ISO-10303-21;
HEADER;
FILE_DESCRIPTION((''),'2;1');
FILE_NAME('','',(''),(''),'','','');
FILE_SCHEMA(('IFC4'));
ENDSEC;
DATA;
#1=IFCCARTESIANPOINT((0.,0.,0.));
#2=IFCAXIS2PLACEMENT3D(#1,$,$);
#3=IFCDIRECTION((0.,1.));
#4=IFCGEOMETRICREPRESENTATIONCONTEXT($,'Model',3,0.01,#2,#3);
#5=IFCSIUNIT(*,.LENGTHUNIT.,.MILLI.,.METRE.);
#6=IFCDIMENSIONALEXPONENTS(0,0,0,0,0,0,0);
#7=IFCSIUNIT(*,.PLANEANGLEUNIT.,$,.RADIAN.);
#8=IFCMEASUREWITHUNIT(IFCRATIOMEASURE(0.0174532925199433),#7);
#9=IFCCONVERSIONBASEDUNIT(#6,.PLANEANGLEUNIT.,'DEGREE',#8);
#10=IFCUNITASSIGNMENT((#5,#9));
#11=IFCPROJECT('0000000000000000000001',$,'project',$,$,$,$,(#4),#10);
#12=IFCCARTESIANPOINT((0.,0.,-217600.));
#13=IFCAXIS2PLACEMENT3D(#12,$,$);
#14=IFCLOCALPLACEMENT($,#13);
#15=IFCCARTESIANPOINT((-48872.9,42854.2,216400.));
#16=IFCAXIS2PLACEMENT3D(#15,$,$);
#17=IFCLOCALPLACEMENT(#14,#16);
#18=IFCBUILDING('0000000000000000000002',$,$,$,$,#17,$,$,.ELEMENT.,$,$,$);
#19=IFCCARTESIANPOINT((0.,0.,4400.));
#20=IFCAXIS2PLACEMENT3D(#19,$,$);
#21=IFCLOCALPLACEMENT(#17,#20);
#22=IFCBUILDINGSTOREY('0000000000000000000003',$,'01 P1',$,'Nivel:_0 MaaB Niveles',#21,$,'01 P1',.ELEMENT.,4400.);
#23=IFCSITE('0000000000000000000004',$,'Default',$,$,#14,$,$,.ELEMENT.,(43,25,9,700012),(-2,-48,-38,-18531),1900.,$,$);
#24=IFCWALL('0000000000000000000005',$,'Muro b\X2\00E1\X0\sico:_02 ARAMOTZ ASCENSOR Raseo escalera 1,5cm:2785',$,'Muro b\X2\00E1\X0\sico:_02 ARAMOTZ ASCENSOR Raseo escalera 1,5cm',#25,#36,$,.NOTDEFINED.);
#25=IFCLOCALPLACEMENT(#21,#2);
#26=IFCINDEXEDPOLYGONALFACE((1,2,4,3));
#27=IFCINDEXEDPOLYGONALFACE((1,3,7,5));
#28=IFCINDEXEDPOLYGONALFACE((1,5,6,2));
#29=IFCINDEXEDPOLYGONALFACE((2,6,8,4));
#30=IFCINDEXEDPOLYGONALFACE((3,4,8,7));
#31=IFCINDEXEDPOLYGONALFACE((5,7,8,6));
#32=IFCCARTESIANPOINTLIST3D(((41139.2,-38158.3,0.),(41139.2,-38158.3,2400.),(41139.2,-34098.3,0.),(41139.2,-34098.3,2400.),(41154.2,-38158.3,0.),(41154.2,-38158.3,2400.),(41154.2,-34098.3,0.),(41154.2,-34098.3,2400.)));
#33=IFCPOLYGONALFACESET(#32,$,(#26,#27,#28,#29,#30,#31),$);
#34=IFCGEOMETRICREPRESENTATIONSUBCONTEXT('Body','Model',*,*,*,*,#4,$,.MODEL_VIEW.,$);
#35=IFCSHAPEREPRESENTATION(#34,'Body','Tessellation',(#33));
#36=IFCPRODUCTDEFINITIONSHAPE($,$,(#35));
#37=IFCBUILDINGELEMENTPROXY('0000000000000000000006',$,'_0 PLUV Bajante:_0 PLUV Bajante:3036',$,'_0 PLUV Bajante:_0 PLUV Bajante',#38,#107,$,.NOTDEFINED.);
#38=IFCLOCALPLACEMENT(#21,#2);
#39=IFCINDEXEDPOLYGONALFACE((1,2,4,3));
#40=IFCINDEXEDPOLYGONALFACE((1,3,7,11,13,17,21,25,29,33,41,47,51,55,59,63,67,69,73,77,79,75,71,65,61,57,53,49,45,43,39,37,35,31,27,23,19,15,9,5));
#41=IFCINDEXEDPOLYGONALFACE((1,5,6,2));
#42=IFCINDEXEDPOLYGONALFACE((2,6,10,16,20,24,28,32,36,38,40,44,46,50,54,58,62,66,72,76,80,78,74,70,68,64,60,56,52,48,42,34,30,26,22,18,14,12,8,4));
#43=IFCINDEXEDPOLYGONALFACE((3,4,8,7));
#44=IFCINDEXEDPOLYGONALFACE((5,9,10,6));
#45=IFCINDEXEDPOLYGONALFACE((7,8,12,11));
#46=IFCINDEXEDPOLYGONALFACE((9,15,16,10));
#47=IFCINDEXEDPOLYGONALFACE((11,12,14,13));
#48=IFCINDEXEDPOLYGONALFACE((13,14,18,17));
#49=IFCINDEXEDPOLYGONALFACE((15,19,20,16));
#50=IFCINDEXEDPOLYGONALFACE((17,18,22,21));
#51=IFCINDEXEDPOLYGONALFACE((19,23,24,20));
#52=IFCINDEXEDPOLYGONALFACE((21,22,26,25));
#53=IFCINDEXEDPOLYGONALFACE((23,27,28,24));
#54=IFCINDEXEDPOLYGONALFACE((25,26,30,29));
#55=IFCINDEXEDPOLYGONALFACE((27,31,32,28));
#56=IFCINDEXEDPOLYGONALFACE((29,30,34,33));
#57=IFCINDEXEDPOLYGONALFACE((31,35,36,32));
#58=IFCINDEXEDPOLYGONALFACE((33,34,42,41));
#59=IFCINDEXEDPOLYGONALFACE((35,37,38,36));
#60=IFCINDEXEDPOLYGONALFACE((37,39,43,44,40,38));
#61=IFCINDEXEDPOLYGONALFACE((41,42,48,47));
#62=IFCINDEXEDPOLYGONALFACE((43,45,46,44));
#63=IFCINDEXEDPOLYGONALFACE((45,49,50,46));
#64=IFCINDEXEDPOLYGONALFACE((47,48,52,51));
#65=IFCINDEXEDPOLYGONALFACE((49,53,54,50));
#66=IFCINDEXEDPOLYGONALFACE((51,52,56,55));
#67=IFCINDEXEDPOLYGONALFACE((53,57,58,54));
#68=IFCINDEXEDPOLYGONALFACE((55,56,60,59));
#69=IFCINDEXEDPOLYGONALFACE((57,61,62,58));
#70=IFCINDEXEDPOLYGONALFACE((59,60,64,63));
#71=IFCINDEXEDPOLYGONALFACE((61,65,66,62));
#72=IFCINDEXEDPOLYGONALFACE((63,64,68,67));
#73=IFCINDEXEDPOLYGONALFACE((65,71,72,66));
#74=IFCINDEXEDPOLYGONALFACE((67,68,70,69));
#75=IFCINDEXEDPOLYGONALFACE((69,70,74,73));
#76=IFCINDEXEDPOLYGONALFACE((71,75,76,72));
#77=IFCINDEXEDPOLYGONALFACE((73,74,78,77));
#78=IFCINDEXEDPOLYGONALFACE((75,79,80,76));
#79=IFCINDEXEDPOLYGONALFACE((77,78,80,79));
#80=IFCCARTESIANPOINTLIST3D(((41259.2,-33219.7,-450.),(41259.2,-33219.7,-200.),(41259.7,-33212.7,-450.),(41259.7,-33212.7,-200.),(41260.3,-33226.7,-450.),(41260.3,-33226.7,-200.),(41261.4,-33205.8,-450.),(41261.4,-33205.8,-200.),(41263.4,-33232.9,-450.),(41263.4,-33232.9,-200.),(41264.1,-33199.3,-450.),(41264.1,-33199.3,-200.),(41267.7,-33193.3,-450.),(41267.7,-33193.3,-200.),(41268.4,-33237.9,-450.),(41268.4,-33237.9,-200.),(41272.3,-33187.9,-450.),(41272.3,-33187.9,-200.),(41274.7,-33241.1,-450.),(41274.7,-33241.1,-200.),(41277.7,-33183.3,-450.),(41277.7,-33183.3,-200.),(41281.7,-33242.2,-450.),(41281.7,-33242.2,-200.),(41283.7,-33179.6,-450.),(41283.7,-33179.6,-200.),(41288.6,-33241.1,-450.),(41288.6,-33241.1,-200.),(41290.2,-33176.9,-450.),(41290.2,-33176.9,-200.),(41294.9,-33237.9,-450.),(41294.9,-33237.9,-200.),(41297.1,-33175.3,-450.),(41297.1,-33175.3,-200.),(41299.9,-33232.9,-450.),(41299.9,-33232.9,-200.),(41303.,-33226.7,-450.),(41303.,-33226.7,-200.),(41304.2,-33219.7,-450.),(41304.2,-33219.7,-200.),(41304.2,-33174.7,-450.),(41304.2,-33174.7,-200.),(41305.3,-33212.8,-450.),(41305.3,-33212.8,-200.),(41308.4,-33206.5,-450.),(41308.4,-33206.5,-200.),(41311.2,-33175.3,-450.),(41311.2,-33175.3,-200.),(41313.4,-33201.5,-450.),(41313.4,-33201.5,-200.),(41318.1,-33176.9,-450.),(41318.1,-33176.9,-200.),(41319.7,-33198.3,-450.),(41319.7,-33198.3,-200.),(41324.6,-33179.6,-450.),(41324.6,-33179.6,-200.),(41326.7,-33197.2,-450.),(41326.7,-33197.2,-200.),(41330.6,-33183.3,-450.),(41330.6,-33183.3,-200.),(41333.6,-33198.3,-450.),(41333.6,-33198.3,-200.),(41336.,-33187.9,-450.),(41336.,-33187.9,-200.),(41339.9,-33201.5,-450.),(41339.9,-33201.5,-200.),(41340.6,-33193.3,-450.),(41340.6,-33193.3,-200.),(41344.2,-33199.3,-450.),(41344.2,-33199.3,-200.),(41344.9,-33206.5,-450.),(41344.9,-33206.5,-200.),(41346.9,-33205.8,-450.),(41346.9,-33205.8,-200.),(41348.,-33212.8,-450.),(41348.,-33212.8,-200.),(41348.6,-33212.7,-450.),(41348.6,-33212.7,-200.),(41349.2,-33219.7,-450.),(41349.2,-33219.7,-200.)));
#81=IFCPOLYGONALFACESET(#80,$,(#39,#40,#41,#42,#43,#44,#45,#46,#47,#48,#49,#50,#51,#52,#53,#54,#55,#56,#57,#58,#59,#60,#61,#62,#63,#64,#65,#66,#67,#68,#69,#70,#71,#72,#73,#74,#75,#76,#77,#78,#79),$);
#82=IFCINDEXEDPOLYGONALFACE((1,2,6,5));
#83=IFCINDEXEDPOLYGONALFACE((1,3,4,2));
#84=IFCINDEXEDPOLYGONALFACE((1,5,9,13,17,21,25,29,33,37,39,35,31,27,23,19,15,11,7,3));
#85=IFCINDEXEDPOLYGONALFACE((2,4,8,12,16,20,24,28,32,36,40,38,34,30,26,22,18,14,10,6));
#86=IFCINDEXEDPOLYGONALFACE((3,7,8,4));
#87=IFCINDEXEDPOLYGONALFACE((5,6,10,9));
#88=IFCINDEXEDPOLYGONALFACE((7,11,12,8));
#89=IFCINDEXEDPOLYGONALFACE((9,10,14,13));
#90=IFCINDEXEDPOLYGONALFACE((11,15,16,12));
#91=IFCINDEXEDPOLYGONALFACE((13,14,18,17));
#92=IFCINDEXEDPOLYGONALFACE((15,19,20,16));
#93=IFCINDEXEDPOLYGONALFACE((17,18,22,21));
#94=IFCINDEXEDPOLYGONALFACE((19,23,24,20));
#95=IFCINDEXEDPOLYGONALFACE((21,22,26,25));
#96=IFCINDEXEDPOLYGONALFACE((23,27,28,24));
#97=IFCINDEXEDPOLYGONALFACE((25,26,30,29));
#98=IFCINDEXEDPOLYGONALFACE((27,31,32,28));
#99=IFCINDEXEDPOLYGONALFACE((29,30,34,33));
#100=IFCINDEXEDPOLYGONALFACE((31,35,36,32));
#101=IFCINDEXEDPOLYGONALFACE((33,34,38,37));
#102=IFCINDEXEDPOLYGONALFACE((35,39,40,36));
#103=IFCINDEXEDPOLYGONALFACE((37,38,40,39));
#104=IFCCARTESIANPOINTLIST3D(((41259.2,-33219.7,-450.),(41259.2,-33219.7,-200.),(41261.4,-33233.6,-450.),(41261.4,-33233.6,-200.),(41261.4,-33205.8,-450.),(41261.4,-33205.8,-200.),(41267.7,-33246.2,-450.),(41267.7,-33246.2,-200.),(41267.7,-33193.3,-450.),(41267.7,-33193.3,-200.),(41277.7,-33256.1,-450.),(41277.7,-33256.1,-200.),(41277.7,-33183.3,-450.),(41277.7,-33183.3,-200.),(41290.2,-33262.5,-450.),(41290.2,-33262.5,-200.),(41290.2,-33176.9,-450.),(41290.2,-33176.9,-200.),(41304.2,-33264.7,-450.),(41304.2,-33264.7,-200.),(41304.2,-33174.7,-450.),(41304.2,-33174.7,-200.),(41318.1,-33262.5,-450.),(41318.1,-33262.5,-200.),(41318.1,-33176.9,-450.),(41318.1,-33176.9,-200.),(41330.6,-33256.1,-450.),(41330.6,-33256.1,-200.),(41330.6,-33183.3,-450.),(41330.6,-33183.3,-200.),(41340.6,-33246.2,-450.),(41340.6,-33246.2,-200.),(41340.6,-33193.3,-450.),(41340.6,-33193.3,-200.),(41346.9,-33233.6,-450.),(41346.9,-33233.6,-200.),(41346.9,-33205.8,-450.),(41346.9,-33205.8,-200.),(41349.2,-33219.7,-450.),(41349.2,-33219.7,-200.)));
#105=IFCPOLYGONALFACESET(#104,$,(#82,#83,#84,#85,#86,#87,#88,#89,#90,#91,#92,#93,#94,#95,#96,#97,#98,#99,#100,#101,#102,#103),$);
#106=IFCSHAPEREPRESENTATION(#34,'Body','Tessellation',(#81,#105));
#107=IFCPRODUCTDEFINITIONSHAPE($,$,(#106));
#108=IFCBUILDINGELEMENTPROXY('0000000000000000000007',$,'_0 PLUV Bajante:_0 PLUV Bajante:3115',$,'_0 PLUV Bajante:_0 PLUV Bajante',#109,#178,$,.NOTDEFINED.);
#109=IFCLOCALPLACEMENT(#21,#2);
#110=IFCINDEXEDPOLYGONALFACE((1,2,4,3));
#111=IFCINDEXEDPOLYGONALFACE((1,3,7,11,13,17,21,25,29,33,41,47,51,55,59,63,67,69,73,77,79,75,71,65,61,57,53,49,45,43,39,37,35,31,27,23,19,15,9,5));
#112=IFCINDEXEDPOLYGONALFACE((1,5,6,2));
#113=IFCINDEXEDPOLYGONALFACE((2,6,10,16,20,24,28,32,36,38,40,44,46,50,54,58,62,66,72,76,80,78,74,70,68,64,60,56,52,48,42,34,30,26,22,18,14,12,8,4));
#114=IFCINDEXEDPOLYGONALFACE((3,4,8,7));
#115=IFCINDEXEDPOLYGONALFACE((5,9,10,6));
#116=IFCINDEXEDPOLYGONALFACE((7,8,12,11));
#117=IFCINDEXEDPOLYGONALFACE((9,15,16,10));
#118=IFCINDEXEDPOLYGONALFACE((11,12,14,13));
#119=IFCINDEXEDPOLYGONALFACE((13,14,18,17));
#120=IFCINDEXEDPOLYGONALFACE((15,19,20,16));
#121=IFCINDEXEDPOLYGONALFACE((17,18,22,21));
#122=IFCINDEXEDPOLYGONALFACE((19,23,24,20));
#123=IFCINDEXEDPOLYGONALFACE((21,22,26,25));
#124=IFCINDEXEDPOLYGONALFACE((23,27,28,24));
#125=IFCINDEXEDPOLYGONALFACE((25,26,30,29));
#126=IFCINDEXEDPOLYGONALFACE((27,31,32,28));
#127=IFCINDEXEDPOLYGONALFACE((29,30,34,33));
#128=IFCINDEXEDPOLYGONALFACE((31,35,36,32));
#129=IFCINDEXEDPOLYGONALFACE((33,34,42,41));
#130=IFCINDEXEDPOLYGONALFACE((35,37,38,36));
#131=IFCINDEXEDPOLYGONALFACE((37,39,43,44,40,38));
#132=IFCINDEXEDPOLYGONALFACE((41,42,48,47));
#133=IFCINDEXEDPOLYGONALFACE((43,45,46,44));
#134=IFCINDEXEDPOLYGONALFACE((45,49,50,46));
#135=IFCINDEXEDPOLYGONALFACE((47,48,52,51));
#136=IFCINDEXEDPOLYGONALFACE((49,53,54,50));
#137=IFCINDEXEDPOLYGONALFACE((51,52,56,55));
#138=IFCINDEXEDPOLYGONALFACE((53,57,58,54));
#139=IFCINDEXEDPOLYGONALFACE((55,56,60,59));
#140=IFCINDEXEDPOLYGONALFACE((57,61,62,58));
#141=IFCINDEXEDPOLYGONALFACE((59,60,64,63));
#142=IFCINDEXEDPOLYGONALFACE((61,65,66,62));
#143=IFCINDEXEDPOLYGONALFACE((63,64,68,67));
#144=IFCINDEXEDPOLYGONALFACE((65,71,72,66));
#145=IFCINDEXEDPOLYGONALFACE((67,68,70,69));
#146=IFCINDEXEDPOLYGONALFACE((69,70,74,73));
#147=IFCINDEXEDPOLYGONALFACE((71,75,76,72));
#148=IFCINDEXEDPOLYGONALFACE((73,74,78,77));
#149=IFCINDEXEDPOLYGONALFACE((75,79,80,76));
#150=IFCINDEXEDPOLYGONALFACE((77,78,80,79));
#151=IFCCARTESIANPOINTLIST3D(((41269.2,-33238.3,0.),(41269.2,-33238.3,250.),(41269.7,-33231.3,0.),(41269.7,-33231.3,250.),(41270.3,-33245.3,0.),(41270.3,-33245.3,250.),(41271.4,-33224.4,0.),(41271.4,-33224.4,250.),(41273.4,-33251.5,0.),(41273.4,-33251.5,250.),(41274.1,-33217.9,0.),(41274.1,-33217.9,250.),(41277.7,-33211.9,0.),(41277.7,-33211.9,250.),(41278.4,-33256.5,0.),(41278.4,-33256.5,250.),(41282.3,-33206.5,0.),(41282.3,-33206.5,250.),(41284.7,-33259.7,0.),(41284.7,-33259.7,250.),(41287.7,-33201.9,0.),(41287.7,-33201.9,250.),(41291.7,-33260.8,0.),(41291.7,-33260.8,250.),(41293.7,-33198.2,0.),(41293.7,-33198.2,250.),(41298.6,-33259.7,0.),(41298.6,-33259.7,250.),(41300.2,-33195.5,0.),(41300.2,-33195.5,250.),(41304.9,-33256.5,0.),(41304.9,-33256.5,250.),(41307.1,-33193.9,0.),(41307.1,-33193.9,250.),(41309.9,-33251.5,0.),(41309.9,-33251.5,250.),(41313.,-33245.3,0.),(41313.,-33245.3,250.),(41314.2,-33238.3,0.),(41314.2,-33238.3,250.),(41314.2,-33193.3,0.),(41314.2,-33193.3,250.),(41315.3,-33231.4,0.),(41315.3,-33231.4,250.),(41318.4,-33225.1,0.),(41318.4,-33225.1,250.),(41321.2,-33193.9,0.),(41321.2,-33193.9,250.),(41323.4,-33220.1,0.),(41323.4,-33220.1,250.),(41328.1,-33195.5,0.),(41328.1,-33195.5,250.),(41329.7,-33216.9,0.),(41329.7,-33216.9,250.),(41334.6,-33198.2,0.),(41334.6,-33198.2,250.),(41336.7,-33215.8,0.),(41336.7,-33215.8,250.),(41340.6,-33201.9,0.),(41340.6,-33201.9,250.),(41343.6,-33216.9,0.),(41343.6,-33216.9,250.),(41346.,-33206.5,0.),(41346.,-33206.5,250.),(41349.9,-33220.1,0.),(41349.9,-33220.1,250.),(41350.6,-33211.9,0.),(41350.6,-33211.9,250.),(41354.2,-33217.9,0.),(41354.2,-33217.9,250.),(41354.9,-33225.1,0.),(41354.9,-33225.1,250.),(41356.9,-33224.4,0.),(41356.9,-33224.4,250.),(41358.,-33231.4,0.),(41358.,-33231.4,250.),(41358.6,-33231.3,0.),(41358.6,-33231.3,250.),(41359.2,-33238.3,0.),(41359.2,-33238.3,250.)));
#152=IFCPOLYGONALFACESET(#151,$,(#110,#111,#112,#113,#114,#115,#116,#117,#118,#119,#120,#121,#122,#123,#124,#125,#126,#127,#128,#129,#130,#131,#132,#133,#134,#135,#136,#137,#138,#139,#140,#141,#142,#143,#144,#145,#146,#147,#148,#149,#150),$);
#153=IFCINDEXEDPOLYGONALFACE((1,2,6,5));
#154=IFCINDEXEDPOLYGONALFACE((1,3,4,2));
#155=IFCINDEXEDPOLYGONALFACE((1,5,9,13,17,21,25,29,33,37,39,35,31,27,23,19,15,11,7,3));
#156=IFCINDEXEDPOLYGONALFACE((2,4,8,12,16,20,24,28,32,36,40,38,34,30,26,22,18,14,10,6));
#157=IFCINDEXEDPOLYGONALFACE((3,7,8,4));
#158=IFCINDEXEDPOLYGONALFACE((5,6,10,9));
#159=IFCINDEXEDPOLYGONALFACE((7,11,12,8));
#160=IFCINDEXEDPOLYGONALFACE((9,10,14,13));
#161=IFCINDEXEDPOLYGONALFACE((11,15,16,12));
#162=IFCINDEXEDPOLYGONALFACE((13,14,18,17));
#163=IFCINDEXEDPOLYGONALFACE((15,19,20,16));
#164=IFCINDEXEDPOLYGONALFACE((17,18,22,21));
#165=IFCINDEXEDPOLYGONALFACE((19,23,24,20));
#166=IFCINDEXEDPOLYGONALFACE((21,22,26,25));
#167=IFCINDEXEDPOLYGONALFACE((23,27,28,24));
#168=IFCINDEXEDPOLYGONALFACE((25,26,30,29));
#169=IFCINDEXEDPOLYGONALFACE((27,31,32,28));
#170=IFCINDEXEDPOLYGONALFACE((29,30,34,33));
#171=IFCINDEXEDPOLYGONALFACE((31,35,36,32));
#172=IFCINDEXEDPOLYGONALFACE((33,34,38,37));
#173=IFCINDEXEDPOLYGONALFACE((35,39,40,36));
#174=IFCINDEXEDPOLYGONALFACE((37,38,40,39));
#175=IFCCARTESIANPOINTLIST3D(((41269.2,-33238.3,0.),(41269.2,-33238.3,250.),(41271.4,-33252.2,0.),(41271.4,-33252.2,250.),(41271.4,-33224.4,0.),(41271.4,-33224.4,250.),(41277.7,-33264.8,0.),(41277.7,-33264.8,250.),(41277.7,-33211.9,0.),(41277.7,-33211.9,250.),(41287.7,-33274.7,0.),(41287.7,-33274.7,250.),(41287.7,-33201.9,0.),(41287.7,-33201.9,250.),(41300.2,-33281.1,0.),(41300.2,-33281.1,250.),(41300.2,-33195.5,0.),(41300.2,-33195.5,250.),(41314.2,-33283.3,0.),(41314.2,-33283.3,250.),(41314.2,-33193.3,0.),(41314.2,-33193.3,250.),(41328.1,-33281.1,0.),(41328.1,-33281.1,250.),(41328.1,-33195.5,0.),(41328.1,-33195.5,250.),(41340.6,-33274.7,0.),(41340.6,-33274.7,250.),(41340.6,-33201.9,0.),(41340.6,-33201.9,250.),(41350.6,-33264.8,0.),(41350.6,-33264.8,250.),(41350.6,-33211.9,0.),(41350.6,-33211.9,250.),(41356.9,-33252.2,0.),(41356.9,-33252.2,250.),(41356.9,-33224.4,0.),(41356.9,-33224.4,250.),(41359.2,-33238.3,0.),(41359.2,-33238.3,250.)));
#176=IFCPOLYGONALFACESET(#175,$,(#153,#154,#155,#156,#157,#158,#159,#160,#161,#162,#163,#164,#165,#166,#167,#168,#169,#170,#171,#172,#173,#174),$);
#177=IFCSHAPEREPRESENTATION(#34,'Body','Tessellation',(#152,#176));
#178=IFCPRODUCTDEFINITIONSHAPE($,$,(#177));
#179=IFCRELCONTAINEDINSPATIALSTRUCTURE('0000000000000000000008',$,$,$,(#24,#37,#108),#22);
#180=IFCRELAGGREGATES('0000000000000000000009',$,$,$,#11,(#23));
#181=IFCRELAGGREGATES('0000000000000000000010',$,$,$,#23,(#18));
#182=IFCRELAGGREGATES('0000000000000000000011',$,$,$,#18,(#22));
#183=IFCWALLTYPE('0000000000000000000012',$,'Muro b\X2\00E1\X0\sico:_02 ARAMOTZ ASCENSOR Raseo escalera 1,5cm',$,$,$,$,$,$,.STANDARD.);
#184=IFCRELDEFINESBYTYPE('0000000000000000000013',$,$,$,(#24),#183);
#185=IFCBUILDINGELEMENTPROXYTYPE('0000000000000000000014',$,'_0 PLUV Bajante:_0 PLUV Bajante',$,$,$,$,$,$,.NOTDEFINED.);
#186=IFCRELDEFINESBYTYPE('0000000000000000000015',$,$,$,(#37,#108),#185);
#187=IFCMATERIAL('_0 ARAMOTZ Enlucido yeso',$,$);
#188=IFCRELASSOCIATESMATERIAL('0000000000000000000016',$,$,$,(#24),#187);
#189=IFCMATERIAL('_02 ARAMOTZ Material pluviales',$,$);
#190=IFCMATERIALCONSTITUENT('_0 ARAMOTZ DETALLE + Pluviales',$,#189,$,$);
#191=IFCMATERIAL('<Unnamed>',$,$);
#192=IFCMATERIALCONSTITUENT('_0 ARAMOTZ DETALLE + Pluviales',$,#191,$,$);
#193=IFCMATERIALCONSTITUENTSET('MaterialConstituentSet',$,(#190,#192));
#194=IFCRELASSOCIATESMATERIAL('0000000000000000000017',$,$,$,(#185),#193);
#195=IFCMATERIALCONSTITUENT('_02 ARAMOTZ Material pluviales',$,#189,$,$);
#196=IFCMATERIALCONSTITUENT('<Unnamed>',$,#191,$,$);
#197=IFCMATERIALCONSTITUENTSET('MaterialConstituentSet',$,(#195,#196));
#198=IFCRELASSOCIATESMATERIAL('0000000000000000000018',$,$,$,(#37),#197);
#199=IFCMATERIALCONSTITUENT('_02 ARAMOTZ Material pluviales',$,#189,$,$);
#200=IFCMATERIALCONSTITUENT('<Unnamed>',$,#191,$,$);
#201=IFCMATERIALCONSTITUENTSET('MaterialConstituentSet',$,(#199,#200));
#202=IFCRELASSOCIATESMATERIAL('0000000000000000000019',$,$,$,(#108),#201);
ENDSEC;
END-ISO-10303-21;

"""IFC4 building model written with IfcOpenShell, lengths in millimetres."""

from ifc_helpers import new_model, entity, si_unit, converted_unit, direction, frame, origin, place, context, subcontext, project, spatial, indexed_curve, outline, extrude, source, transform, mapped, material, constituent, constituent_set, type_object, type_shapes, element, save


model = new_model("IFC4")

# Units and contexts
model_context = context("Model", 3, precision=0.01, world=origin(), true_north=direction((0.0, 1.0)))
body_context = subcontext(model_context, "Body", "Model", "MODEL_VIEW")
ifc_project = project(units=[si_unit("LENGTHUNIT", "METRE", prefix="MILLI"), converted_unit("PLANEANGLEUNIT", "DEGREE", entity("IfcRatioMeasure", 0.0174532925199433), si_unit("PLANEANGLEUNIT", "RADIAN"), dimensions=[0, 0, 0, 0, 0, 0, 0])], contexts=[model_context])

# Site, building, storey
site_placement = place(None, frame((0.0, 0.0, -217600.0)))
site = spatial("IfcSite", under=ifc_project, at=site_placement, Name="Default", CompositionType="ELEMENT", RefLatitude=(43, 25, 9, 700012), RefLongitude=(-2, -48, -38, -18531), RefElevation=1900.0)
building_placement = place(site_placement, frame((-48872.9, 42854.2, 216400.0)))
building = spatial("IfcBuilding", under=site, at=building_placement, CompositionType="ELEMENT")
storey_placement = place(building_placement, frame((0.0, 0.0, 4400.0)))
storey = spatial("IfcBuildingStorey", under=building, at=storey_placement, Name="01 P1", ObjectType="Nivel:_0 MaaB Niveles", LongName="01 P1", CompositionType="ELEMENT", Elevation=4400.0)

# Wall
ifc_material_1 = material(Name="_0 ARAMOTZ Enlucido yeso")
wall_type_1 = type_object("IfcWallType", Name="Muro básico:_02 ARAMOTZ ASCENSOR Raseo escalera 1,5cm", PredefinedType="STANDARD")
wall_1_placement = place(storey_placement, frame((41146.7, -38158.3, 0.0), z_axis=(0.0, 0.0, 1.0), x_axis=(0.0, 1.0, 0.0)))
element("IfcWall", 1, at=wall_1_placement, inside=storey, type_object=wall_type_1, material=ifc_material_1, Name="Muro básico:_02 ARAMOTZ ASCENSOR Raseo escalera 1,5cm:2785", ObjectType="Muro básico:_02 ARAMOTZ ASCENSOR Raseo escalera 1,5cm", PredefinedType="NOTDEFINED", context=body_context, shape_type="SweptSolid", body=[
    extrude(outline(indexed_curve([(4060.0, 7.5), (0.0, 7.5), (0.0, -7.5), (4060.0, -7.5), (4060.0, 7.5)], self_intersect=False)), origin(), (0.0, 0.0, 1.0), 2400.0),
])

# Building element proxies
ifc_material_2 = material(Name="_02 ARAMOTZ Material pluviales")
ifc_constituent_1 = constituent(ifc_material_2, Name="_02 ARAMOTZ Material pluviales")
ifc_material_3 = material(Name="<Unnamed>")
ifc_constituent_2 = constituent(ifc_material_3, Name="<Unnamed>")
ifc_constituent_set_1 = constituent_set(constituents=[ifc_constituent_1, ifc_constituent_2], Name="MaterialConstituentSet")
ifc_constituent_3 = constituent(ifc_material_2, Name="_0 ARAMOTZ DETALLE + Pluviales")
ifc_constituent_4 = constituent(ifc_material_3, Name="_0 ARAMOTZ DETALLE + Pluviales")
ifc_constituent_set_2 = constituent_set(constituents=[ifc_constituent_3, ifc_constituent_4], Name="MaterialConstituentSet")
building_element_proxy_type_1 = type_object("IfcBuildingElementProxyType", Name="_0 PLUV Bajante:_0 PLUV Bajante", PredefinedType="NOTDEFINED", material=ifc_constituent_set_2)
shared_shape_1 = source(origin(), body_context, "Body", "SweptSolid", [
    extrude(outline(indexed_curve([(11.2, 0.0), (18.2, 1.1), (24.5, 4.3), (29.5, 9.3), (32.6, 15.5), (33.7, 22.5), (32.6, 29.5), (29.5, 35.7), (24.5, 40.7), (18.2, 43.9), (11.3, 45.0), (4.2, 44.4), (-2.7, 42.8), (-9.2, 40.1), (-15.2, 36.4), (-20.6, 31.8), (-25.2, 26.5), (-28.8, 20.4), (-31.5, 13.9), (-33.2, 7.0), (-33.8, 0.0), (-33.2, -7.0), (-31.5, -13.9), (-28.8, -20.4), (-25.2, -26.5), (-20.6, -31.8), (-15.2, -36.4), (-9.2, -40.1), (-2.7, -42.8), (4.2, -44.4), (11.2, -45.0), (4.3, -43.9), (-2.0, -40.7), (-7.0, -35.7), (-10.1, -29.5), (-11.3, -22.5), (-10.1, -15.5), (-7.0, -9.3), (-2.0, -4.3), (4.3, -1.1), (11.2, 0.0)], self_intersect=False)), frame((-11.2, 0.0, 0.0), z_axis=(0.0, 0.0, -1.0), x_axis=(1.0, 0.0, 0.0)), (0.0, 0.0, -1.0), 250.0),
    extrude(outline(indexed_curve([(45.0, 0.0), (42.8, 13.9), (36.4, 26.5), (26.5, 36.4), (13.9, 42.8), (0.0, 45.0), (-13.9, 42.8), (-26.5, 36.4), (-36.4, 26.5), (-42.8, 13.9), (-45.0, 0.0), (-42.8, -13.9), (-36.4, -26.5), (-26.5, -36.4), (-13.9, -42.8), (0.0, -45.0), (13.9, -42.8), (26.5, -36.4), (36.4, -26.5), (42.8, -13.9), (45.0, 0.0)], self_intersect=False)), origin(), (0.0, 0.0, 1.0), 250.0),
])
type_shapes(building_element_proxy_type_1, [shared_shape_1])
proxy_1_placement = place(storey_placement, frame((41304.2, -33219.7, -450.0), z_axis=(0.0, 0.0, 1.0), x_axis=(0.0, -1.0, 0.0)))
element("IfcBuildingElementProxy", 2, at=proxy_1_placement, inside=storey, type_object=building_element_proxy_type_1, material=ifc_constituent_set_1, Name="_0 PLUV Bajante:_0 PLUV Bajante:3036", ObjectType="_0 PLUV Bajante:_0 PLUV Bajante", PredefinedType="NOTDEFINED", context=body_context, shape_type="MappedRepresentation", body=[
    mapped(shared_shape_1, transform((0.0, 0.0, 0.0), scale=1.0)),
])
ifc_constituent_5 = constituent(ifc_material_2, Name="_02 ARAMOTZ Material pluviales")
ifc_constituent_6 = constituent(ifc_material_3, Name="<Unnamed>")
ifc_constituent_set_3 = constituent_set(constituents=[ifc_constituent_5, ifc_constituent_6], Name="MaterialConstituentSet")
proxy_2_placement = place(storey_placement, frame((41314.2, -33238.3, 0.0), z_axis=(0.0, 0.0, 1.0), x_axis=(0.0, -1.0, 0.0)))
element("IfcBuildingElementProxy", 3, at=proxy_2_placement, inside=storey, type_object=building_element_proxy_type_1, material=ifc_constituent_set_3, Name="_0 PLUV Bajante:_0 PLUV Bajante:3115", ObjectType="_0 PLUV Bajante:_0 PLUV Bajante", PredefinedType="NOTDEFINED", context=body_context, shape_type="MappedRepresentation", body=[
    mapped(shared_shape_1, transform((0.0, 0.0, 0.0), scale=1.0)),
])

save(model, "model.ifc")
